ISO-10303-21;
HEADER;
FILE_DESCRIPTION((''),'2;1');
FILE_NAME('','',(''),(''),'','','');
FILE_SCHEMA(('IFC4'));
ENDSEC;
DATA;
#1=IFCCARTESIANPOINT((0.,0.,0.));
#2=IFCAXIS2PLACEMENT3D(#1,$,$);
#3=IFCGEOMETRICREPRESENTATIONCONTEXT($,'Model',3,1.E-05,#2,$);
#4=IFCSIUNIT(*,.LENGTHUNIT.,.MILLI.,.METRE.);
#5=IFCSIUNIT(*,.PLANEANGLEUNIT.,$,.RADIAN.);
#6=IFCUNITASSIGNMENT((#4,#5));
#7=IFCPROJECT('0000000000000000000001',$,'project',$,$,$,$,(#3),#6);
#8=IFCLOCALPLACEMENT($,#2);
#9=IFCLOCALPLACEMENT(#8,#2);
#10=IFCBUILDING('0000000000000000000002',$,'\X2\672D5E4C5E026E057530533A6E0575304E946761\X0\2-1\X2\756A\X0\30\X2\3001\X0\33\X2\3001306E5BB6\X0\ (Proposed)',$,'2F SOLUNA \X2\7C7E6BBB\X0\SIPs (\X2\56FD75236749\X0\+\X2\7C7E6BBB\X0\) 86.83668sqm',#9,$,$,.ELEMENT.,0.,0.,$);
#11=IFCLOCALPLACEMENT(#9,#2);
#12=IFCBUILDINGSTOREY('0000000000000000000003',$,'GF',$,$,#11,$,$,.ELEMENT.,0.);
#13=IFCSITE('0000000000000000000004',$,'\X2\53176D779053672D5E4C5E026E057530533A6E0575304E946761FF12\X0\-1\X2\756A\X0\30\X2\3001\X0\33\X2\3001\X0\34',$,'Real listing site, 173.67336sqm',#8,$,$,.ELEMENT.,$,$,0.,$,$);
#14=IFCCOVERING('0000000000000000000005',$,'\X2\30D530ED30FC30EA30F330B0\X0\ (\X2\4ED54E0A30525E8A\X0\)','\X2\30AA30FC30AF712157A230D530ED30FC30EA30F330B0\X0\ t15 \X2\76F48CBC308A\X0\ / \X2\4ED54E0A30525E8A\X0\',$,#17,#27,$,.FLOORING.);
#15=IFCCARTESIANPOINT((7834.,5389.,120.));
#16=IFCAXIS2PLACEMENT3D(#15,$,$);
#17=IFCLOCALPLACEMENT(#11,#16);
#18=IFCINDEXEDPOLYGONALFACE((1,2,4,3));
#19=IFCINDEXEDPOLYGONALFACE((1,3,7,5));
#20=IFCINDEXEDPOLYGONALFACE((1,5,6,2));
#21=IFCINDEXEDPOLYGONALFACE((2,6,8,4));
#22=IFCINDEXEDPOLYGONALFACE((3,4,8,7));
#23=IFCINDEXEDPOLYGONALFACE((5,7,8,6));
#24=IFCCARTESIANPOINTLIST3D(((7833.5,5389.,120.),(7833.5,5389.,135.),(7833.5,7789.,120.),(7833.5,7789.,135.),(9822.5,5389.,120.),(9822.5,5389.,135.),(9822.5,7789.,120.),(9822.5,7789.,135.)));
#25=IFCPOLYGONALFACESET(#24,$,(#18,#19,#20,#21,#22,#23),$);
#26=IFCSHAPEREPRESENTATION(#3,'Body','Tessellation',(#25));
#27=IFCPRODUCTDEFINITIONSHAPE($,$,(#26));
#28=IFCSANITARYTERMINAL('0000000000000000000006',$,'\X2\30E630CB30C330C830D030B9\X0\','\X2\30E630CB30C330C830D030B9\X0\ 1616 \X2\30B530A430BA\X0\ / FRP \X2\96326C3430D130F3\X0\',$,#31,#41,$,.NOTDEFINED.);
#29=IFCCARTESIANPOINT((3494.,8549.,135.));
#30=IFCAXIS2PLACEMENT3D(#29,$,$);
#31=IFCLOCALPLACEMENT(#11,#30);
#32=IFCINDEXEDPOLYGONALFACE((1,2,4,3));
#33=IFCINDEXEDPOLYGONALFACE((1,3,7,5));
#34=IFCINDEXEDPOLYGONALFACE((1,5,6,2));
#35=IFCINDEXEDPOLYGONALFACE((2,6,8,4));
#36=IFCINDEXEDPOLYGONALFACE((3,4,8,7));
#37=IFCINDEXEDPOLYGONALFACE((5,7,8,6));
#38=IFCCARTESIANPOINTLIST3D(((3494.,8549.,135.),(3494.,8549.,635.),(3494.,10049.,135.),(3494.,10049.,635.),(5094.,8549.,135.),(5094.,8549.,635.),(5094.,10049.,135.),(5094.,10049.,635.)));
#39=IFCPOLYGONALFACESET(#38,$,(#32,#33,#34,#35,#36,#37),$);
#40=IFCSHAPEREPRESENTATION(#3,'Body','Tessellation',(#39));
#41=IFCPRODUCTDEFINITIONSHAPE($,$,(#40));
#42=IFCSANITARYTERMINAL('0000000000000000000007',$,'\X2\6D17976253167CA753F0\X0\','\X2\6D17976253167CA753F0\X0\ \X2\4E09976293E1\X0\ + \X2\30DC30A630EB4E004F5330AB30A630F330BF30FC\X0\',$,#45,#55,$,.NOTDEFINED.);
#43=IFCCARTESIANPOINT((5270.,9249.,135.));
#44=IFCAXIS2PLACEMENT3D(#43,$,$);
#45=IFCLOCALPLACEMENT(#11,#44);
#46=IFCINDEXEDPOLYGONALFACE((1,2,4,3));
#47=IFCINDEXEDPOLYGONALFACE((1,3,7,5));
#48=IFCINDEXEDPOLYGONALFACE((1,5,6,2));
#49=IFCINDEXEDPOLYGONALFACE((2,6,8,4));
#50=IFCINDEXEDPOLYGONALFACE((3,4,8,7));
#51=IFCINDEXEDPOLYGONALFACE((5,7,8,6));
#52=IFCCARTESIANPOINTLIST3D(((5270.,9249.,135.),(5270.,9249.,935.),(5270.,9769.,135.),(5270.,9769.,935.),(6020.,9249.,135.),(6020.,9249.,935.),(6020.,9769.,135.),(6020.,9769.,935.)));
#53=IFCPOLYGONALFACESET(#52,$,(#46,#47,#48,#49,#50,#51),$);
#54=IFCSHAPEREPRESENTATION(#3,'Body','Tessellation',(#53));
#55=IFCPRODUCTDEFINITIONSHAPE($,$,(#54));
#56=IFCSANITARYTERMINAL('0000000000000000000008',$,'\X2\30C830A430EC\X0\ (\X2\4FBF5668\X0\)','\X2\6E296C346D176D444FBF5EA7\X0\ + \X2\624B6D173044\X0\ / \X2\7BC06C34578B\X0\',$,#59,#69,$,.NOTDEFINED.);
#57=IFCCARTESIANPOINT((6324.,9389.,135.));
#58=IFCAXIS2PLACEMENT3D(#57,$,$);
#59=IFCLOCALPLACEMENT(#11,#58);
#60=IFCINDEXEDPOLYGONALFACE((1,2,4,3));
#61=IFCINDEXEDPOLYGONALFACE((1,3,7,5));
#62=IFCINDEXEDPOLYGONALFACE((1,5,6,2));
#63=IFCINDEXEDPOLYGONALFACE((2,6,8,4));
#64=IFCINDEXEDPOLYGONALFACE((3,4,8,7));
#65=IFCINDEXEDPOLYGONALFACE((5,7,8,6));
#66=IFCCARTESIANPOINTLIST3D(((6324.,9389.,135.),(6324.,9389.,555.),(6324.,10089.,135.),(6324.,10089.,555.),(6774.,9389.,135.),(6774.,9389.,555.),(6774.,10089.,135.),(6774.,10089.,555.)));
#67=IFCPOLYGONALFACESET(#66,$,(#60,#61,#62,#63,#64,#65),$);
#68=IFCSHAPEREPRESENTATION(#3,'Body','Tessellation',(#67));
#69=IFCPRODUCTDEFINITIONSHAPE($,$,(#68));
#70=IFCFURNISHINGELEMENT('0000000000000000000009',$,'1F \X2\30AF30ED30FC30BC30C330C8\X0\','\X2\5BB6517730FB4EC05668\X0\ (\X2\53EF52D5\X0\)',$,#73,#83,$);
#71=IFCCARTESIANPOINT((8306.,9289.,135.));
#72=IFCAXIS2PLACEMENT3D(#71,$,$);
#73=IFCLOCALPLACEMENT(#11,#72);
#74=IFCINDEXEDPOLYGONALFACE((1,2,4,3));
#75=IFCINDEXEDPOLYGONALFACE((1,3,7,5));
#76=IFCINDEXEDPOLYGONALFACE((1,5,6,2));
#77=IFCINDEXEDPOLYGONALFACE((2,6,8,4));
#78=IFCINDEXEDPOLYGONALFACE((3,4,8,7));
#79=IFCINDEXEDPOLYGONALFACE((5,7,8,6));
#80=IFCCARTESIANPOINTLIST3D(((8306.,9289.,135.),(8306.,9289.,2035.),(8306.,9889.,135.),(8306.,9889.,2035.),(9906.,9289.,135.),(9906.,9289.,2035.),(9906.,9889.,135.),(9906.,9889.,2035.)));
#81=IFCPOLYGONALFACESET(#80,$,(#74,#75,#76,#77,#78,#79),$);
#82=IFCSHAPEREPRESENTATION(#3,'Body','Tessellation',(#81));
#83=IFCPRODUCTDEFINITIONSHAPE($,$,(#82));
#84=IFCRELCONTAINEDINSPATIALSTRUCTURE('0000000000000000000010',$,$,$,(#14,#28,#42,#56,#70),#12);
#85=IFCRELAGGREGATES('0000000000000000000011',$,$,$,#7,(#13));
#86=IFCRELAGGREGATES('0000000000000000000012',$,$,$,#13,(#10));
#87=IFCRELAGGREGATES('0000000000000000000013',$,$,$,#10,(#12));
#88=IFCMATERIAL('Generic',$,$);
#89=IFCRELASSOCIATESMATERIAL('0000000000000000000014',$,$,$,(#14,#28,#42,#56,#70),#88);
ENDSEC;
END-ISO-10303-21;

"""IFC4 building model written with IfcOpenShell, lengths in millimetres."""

from ifc_helpers import new_model, si_unit, frame, frame_2d, origin, place, context, project, spatial, rectangle, extrude, material, element, save


model = new_model("IFC4")

# Units and contexts
model_context = context("Model", 3, precision=1e-05, world=origin())
ifc_project = project(units=[si_unit("LENGTHUNIT", "METRE", prefix="MILLI"), si_unit("PLANEANGLEUNIT", "RADIAN")], contexts=[model_context])

# Site, building, storey
site_placement = place(None, origin())
site = spatial("IfcSite", under=ifc_project, at=site_placement, Name="北海道札幌市清田区清田五条２-1番30、33、34", ObjectType="Real listing site, 173.67336sqm", CompositionType="ELEMENT", RefElevation=0.0)
building_placement = place(site_placement, origin())
building = spatial("IfcBuilding", under=site, at=building_placement, Name="札幌市清田区清田五条2-1番30、33、の家 (Proposed)", ObjectType="2F SOLUNA 籾殻SIPs (国産杉+籾殻) 86.83668sqm", CompositionType="ELEMENT", ElevationOfRefHeight=0.0, ElevationOfTerrain=0.0)
storey_placement = place(building_placement, origin())
storey = spatial("IfcBuildingStorey", under=building, at=storey_placement, Name="GF", CompositionType="ELEMENT", Elevation=0.0)

# Covering
ifc_material_1 = material(Name="Generic")
covering_1_placement = place(storey_placement, frame((7834.0, 5389.0, 120.0)))
element("IfcCovering", 1, at=covering_1_placement, inside=storey, material=ifc_material_1, Name="フローリング (仕上げ床)", Description="オーク無垢フローリング t15 直貼り / 仕上げ床", PredefinedType="FLOORING", context=model_context, shape_type="SweptSolid", body=[
    extrude(rectangle(XDim=1989.0, YDim=2400.0, at=frame_2d((994.0, 1200.0))), frame((7834.0, 5389.0, 120.0)), (0.0, 0.0, 1.0), 15.0),
])

# Sanitary terminals
sanitary_terminal_1_placement = place(storey_placement, frame((3494.0, 8549.0, 135.0)))
element("IfcSanitaryTerminal", 2, at=sanitary_terminal_1_placement, inside=storey, material=ifc_material_1, Name="ユニットバス", Description="ユニットバス 1616 サイズ / FRP 防水パン", PredefinedType="NOTDEFINED", context=model_context, shape_type="SweptSolid", body=[
    extrude(rectangle(XDim=1600.0, YDim=1500.0, at=frame_2d((800.0, 750.0))), frame((3494.0, 8549.0, 135.0)), (0.0, 0.0, 1.0), 500.0),
])
sanitary_terminal_2_placement = place(storey_placement, frame((5270.0, 9249.0, 135.0)))
element("IfcSanitaryTerminal", 3, at=sanitary_terminal_2_placement, inside=storey, material=ifc_material_1, Name="洗面化粧台", Description="洗面化粧台 三面鏡 + ボウル一体カウンター", PredefinedType="NOTDEFINED", context=model_context, shape_type="SweptSolid", body=[
    extrude(rectangle(XDim=750.0, YDim=520.0, at=frame_2d((375.0, 260.0))), frame((5270.0, 9249.0, 135.0)), (0.0, 0.0, 1.0), 800.0),
])
sanitary_terminal_3_placement = place(storey_placement, frame((6324.0, 9389.0, 135.0)))
element("IfcSanitaryTerminal", 4, at=sanitary_terminal_3_placement, inside=storey, material=ifc_material_1, Name="トイレ (便器)", Description="温水洗浄便座 + 手洗い / 節水型", PredefinedType="NOTDEFINED", context=model_context, shape_type="SweptSolid", body=[
    extrude(rectangle(XDim=450.0, YDim=700.0, at=frame_2d((225.0, 350.0))), frame((6324.0, 9389.0, 135.0)), (0.0, 0.0, 1.0), 420.0),
])

# Furnishing element
furnishing_placement = place(storey_placement, frame((8306.0, 9289.0, 135.0)))
element("IfcFurnishingElement", 5, at=furnishing_placement, inside=storey, material=ifc_material_1, Name="1F クローゼット", Description="家具・什器 (可動)", context=model_context, shape_type="SweptSolid", body=[
    extrude(rectangle(XDim=1600.0, YDim=600.0, at=frame_2d((800.0, 300.0))), frame((8306.0, 9289.0, 135.0)), (0.0, 0.0, 1.0), 1900.0),
])

save(model, "model.ifc")
